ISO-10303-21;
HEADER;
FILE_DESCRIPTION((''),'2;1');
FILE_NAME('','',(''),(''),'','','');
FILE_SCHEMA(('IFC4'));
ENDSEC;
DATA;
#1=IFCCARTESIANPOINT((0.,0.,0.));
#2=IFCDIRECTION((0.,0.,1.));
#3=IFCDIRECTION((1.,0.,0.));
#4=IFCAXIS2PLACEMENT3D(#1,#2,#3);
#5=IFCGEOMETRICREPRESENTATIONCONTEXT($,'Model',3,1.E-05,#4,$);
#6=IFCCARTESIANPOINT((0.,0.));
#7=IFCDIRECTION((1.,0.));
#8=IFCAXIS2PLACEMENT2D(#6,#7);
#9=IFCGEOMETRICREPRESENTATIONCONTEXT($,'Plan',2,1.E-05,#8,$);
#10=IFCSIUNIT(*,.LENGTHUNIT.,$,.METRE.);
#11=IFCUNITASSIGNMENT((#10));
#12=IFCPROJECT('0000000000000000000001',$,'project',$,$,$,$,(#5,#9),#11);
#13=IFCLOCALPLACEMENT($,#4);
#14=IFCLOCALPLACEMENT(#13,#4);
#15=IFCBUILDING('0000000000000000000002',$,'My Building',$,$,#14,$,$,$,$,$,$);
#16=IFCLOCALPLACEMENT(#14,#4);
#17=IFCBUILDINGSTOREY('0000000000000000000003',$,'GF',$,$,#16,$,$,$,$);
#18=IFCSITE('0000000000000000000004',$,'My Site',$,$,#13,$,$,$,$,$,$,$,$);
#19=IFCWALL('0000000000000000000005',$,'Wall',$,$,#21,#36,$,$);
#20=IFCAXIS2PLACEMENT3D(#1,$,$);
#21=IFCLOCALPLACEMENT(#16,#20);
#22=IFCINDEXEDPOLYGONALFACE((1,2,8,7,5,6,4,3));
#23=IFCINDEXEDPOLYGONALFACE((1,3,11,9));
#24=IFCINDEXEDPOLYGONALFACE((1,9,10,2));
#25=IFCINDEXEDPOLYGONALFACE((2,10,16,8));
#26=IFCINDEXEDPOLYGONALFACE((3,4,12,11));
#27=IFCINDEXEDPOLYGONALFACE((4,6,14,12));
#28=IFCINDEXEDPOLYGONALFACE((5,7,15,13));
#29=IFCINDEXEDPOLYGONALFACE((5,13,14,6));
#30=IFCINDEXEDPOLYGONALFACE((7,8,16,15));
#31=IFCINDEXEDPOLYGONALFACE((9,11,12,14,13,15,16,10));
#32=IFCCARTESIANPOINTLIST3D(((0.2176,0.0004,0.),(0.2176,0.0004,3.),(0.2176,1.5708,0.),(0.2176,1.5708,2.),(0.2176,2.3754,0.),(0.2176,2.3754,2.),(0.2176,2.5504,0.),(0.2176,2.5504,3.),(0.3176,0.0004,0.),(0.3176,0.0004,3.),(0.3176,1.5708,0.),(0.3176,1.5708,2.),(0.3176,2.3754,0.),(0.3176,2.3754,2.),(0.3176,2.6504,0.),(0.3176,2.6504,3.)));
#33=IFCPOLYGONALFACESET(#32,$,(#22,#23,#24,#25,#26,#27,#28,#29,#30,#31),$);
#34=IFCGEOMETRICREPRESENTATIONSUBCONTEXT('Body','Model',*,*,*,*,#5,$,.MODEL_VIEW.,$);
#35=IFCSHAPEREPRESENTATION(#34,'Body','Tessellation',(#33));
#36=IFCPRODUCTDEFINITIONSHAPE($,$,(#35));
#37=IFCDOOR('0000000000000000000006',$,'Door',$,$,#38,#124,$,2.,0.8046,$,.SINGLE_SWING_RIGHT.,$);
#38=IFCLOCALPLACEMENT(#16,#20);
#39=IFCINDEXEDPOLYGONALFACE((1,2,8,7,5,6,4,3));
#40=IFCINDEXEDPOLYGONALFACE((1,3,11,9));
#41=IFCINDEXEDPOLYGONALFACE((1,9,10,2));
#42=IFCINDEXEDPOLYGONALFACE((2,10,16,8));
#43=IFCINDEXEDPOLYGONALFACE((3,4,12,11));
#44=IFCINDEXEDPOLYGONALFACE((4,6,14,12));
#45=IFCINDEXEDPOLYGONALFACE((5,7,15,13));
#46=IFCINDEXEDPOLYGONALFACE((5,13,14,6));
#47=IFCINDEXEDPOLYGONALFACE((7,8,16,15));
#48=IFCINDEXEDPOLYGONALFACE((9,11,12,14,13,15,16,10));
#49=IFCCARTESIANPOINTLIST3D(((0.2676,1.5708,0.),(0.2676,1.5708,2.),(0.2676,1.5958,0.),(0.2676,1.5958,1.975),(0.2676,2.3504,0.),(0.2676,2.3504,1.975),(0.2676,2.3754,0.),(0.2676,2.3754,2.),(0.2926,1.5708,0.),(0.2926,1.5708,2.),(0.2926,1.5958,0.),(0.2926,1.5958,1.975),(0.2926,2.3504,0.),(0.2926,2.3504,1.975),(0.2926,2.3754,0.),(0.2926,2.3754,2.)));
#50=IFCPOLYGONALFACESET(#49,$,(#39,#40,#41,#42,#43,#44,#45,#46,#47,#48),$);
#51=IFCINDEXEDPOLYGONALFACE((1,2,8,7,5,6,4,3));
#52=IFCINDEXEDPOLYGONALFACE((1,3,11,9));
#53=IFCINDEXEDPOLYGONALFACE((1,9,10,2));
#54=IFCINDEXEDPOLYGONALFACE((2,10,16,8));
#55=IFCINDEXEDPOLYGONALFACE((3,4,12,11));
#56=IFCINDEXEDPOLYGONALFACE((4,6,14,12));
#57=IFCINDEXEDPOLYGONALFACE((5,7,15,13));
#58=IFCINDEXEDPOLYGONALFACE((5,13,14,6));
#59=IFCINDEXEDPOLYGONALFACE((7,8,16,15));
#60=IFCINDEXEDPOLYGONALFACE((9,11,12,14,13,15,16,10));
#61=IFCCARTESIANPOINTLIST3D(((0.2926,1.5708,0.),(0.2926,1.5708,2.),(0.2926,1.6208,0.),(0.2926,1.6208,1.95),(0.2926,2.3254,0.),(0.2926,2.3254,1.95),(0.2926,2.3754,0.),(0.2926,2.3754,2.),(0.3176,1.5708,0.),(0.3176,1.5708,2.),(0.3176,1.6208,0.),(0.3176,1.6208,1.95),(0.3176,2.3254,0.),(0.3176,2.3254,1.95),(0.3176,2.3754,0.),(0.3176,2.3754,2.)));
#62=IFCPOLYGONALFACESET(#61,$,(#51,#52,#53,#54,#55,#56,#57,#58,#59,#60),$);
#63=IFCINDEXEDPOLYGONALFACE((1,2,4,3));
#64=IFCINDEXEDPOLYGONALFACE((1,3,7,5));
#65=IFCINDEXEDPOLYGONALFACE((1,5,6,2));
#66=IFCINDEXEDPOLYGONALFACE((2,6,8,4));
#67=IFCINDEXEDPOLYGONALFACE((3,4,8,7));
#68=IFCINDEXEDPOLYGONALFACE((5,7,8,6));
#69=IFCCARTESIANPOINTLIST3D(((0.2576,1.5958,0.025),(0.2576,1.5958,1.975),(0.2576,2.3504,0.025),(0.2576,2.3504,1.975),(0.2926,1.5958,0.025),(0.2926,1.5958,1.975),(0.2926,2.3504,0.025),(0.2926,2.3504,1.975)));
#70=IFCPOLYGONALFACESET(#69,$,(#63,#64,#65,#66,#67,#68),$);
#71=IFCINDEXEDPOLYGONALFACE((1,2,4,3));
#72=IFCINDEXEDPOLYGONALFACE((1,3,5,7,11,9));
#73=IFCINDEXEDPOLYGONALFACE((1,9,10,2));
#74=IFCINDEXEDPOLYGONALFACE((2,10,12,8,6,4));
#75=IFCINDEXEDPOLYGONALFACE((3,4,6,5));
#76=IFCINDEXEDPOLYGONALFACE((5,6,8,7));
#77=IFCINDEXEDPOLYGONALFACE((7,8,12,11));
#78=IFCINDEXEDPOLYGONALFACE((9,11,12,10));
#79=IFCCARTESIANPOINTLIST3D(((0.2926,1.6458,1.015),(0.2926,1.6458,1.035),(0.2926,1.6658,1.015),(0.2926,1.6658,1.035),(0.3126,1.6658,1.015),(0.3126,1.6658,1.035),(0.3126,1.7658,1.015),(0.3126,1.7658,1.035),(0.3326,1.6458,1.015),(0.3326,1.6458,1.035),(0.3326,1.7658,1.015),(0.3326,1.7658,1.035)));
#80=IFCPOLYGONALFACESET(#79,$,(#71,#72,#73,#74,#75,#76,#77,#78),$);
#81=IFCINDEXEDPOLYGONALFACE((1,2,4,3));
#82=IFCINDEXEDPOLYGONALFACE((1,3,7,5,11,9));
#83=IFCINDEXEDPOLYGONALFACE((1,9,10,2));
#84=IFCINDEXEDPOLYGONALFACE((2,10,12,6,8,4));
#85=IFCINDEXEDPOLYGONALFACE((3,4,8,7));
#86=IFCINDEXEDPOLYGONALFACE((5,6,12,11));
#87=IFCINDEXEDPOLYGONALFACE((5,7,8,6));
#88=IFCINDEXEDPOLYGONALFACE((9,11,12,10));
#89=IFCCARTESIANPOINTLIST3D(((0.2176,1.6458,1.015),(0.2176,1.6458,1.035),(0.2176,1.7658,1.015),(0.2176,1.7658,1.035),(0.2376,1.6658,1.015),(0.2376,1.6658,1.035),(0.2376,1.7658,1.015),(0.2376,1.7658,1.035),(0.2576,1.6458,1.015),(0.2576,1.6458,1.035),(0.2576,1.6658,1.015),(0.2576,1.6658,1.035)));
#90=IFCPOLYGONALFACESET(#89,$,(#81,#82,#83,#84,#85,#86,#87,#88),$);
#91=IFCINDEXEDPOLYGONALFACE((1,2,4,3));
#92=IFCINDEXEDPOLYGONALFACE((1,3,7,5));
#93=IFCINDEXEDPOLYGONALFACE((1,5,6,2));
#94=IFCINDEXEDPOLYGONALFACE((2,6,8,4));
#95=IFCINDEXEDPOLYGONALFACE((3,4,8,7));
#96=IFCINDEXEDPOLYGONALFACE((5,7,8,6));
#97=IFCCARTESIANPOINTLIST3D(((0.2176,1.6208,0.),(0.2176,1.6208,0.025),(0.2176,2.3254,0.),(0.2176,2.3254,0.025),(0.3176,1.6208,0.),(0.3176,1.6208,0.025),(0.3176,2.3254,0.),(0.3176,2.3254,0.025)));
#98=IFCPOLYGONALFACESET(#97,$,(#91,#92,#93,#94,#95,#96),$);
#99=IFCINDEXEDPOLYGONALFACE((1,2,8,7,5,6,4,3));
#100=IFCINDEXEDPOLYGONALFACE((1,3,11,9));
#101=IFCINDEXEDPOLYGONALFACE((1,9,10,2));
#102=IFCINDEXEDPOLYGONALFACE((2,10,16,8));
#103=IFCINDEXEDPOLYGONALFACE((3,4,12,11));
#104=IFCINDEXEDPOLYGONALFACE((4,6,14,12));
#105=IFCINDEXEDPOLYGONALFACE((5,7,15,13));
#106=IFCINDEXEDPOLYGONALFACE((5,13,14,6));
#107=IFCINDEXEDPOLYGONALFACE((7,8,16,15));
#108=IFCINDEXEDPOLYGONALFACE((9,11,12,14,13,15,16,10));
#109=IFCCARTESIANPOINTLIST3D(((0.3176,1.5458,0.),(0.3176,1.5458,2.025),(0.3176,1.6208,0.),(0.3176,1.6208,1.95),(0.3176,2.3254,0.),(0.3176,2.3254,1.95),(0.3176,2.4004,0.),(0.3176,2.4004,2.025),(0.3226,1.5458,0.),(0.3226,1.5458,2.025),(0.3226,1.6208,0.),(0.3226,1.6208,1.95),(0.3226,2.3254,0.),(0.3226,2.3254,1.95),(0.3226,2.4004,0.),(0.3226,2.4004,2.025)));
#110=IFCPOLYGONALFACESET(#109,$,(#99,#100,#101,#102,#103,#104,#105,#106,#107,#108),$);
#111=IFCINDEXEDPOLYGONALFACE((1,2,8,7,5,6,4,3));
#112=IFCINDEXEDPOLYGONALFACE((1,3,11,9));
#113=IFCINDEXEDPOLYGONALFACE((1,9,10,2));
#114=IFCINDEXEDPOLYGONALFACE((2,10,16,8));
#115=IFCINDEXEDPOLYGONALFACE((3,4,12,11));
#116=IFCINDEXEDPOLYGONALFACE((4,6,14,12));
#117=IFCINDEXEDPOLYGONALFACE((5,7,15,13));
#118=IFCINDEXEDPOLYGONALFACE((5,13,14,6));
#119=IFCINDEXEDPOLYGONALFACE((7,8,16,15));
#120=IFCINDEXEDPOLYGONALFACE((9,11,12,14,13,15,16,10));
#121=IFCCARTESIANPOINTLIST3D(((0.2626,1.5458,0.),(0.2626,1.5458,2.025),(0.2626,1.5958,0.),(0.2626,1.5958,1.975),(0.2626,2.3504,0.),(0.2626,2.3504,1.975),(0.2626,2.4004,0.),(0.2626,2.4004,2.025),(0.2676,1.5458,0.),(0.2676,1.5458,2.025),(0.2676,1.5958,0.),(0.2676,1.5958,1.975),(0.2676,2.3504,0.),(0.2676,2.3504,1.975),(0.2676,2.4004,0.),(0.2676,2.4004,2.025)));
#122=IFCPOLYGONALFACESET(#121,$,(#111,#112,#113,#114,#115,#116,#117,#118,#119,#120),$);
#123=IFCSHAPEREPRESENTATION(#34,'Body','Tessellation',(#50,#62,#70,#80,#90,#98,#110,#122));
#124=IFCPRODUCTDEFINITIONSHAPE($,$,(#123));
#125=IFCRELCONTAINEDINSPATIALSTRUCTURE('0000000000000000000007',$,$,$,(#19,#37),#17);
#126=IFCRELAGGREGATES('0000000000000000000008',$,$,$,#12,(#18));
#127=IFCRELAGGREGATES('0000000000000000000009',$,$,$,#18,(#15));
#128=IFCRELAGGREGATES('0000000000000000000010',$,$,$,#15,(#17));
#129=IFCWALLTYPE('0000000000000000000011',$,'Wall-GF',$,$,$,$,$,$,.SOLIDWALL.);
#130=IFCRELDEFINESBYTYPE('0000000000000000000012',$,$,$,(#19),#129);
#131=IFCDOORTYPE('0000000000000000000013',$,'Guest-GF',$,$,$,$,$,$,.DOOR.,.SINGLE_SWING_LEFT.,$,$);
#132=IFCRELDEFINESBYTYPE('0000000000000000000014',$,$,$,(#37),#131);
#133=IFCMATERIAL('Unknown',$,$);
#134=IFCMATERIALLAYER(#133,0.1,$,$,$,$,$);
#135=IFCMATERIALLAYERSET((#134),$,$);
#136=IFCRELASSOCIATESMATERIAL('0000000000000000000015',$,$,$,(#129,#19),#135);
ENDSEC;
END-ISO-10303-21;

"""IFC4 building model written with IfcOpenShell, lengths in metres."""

from ifc_helpers import new_model, entity, si_unit, frame, origin_with_axes, origin_2d_with_axis, place, context, subcontext, project, spatial, line, indexed_curve, outline, extrude, shape, source, transform, mapped, material, layer, layer_set, layer_usage, type_object, type_shapes, element, fill, save


model = new_model("IFC4")

# Units and contexts
model_context = context("Model", 3, precision=1e-05, world=origin_with_axes())
plan_context = context("Plan", 2, precision=1e-05, world=origin_2d_with_axis())
body_context_1 = subcontext(model_context, "Body", "Model", "MODEL_VIEW")
body_context_2 = subcontext(plan_context, "Body", "Plan", "PLAN_VIEW")
ifc_project = project(units=[si_unit("LENGTHUNIT", "METRE")], contexts=[model_context, plan_context])

# Site, building, storey
site_placement = place(None, origin_with_axes())
site = spatial("IfcSite", under=ifc_project, at=site_placement, Name="My Site")
building_placement = place(site_placement, origin_with_axes())
building = spatial("IfcBuilding", under=site, at=building_placement, Name="My Building")
storey_placement = place(building_placement, origin_with_axes())
storey = spatial("IfcBuildingStorey", under=building, at=storey_placement, Name="GF")

# Shared definitions
ifc_material = material(Name="Unknown")

# Shared definitions
ifc_layer_1 = layer(ifc_material, 0.1)
ifc_layer_set_1 = layer_set([ifc_layer_1])
wall_type = type_object("IfcWallType", Name="Wall-GF", PredefinedType="SOLIDWALL", material=ifc_layer_set_1)

# Wall, opening, door
ifc_layer_usage_1 = layer_usage(ifc_layer_set_1, "AXIS2", "POSITIVE", 0.0)
wall_1_placement = place(storey_placement, frame((0.3176, 0.0004, 0.0), z_axis=(0.0, 0.0, 1.0), x_axis=(0.0, 1.0, 0.0)))
wall_1 = element("IfcWall", 1, at=wall_1_placement, inside=storey, type_object=wall_type, material=ifc_layer_usage_1, Name="Wall", context=body_context_1, shape_type="SweptSolid", body=[
    extrude(outline(indexed_curve([(0.0, 0.0), (0.0, 0.1), (2.55, 0.1), (2.65, 0.0)], segments=[line(1, 2, 3, 4, 1)])), origin_with_axes(), (0.0, 0.0, 1.0), 3.0),
])
shared_shape_1 = source(origin_with_axes(), body_context_1, "Body", "SweptSolid", [
    extrude(outline(indexed_curve([(0.0, 0.0), (0.8046, 0.0), (0.8046, 2.0), (0.0, 2.0)], segments=[line(1, 2, 3, 4, 1)])), frame((0.0, -0.6, 0.0), z_axis=(0.0, -1.0, 0.0), x_axis=(1.0, 0.0, 0.0)), (0.0, 0.0, -1.0), 1.2),
])
opening_1_placement = place(wall_1_placement, frame((1.5705, 0.0, 0.0), z_axis=(0.0, 0.0, 1.0), x_axis=(1.0, 0.0, 0.0)))
opening_1 = element("IfcOpeningElement", 2, at=opening_1_placement, cuts=wall_1, PredefinedType="OPENING", context=body_context_1, shape_type="MappedRepresentation", body=[
    mapped(shared_shape_1, transform((0.0, 0.0, 0.0), x_axis=(1.0, 0.0, 0.0), y_axis=(0.0, 1.0, 0.0), z_axis=(0.0, 0.0, 1.0), scale=1.0)),
])
door_type_1 = type_object("IfcDoorType", Name="Guest-GF", OperationType="SINGLE_SWING_LEFT", PredefinedType="DOOR")
shared_shape_2 = source(origin_with_axes(), body_context_1, "Body", "SweptSolid", [
    extrude(outline(indexed_curve([(0.0, 0.0), (0.0, 2.0), (0.8046, 2.0), (0.8046, 0.0), (0.7796, 0.0), (0.7796, 1.975), (0.025, 1.975), (0.025, 0.0)], segments=[line(1, 2, 3, 4, 5, 6, 7, 8, 1)])), frame((0.0, 0.025, 0.0), z_axis=(0.0, -1.0, 0.0), x_axis=(1.0, 0.0, 0.0)), (0.0, 0.0, -1.0), 0.025),
    extrude(outline(indexed_curve([(0.0, 0.0), (0.0, 2.0), (0.8046, 2.0), (0.8046, 0.0), (0.7546, 0.0), (0.7546, 1.95), (0.05, 1.95), (0.05, 0.0)], segments=[line(1, 2, 3, 4, 5, 6, 7, 8, 1)])), frame((0.0, 0.0, 0.0), z_axis=(0.0, -1.0, 0.0), x_axis=(1.0, 0.0, 0.0)), (0.0, 0.0, -1.0), 0.025),
    extrude(outline(indexed_curve([(0.0, 0.0), (0.7546, 0.0), (0.7546, 0.035), (0.0, 0.035)], segments=[line(1, 2, 3, 4, 1)])), frame((0.025, 0.025, 0.025), z_axis=(0.0, 0.0, 1.0), x_axis=(1.0, 0.0, 0.0)), (0.0, 0.0, 1.0), 1.95),
    extrude(outline(indexed_curve([(0.0, 0.0), (0.0, -0.04), (0.12, -0.04), (0.12, -0.02), (0.02, -0.02), (0.02, 0.0)], segments=[line(1, 2, 3, 4, 5, 6, 1)])), frame((0.075, 0.025, 1.015), z_axis=(0.0, 0.0, 1.0), x_axis=(1.0, 0.0, 0.0)), (0.0, 0.0, 1.0), 0.02),
    extrude(outline(indexed_curve([(0.0, 0.0), (0.0, 0.04), (0.12, 0.04), (0.12, 0.02), (0.02, 0.02), (0.02, 0.0)], segments=[line(1, 2, 3, 4, 5, 6, 1)])), frame((0.075, 0.06, 1.015), z_axis=(0.0, 0.0, 1.0), x_axis=(1.0, 0.0, 0.0)), (0.0, 0.0, 1.0), 0.02),
    extrude(outline(indexed_curve([(0.0, 0.0), (0.7046, 0.0), (0.7046, 0.1), (0.0, 0.1)], segments=[line(1, 2, 3, 4, 1)])), frame((0.05, 0.0, 0.0), z_axis=(0.0, 0.0, 1.0), x_axis=(1.0, 0.0, 0.0)), (0.0, 0.0, 1.0), 0.025),
    extrude(outline(indexed_curve([(0.0, 0.0), (0.0, 2.025), (0.8546, 2.025), (0.8546, 0.0), (0.7796, 0.0), (0.7796, 1.95), (0.075, 1.95), (0.075, 0.0)], segments=[line(1, 2, 3, 4, 5, 6, 7, 8, 1)])), frame((-0.025, -0.005, 0.0), z_axis=(0.0, -1.0, 0.0), x_axis=(1.0, 0.0, 0.0)), (0.0, 0.0, -1.0), 0.005),
    extrude(outline(indexed_curve([(0.0, 0.0), (0.0, 2.025), (0.8546, 2.025), (0.8546, 0.0), (0.8046, 0.0), (0.8046, 1.975), (0.05, 1.975), (0.05, 0.0)], segments=[line(1, 2, 3, 4, 5, 6, 7, 8, 1)])), frame((-0.025, 0.05, 0.0), z_axis=(0.0, -1.0, 0.0), x_axis=(1.0, 0.0, 0.0)), (0.0, 0.0, -1.0), 0.005),
])
shared_shape_3 = source(origin_with_axes(), body_context_2, "Body", "Curve2D", [
    entity("IfcIndexedPolyCurve", entity("IfcCartesianPointList2D", [[0.0, 0.0], [0.0, 0.05], [0.025, 0.05], [0.025, 0.025], [0.05, 0.025], [0.05, 0.0]]), [entity("IfcLineIndex", [1, 2, 3, 4, 5, 6, 1])]),
    entity("IfcIndexedPolyCurve", entity("IfcCartesianPointList2D", [[0.8046, 0.0], [0.8046, 0.05], [0.7796, 0.05], [0.7796, 0.025], [0.7546, 0.025], [0.7546, 0.0]]), [entity("IfcLineIndex", [1, 2, 3, 4, 5, 6, 1])]),
    entity("IfcTrimmedCurve", entity("IfcEllipse", entity("IfcAxis2Placement2D", entity("IfcCartesianPoint", [0.7446, 0.05]), entity("IfcDirection", [1.0, 0.0])), 0.7196, 0.7546), [entity("IfcCartesianPoint", [0.7446, 0.8046])], [entity("IfcCartesianPoint", [0.025, 0.05])], True, "CARTESIAN"),
    entity("IfcIndexedPolyCurve", entity("IfcCartesianPointList2D", [[0.7796, 0.05], [0.7446, 0.05], [0.7446, 0.8046], [0.7796, 0.8046]]), [entity("IfcLineIndex", [1, 2, 3, 4, 1])]),
])
type_shapes(door_type_1, [shared_shape_2, shared_shape_3])
door_1_placement = place(opening_1_placement, frame((0.0, 0.0, 0.0), z_axis=(0.0, 0.0, 1.0), x_axis=(1.0, 0.0, 0.0)))
door_1 = element("IfcDoor", 3, at=door_1_placement, inside=storey, type_object=door_type_1, Name="Door", OperationType="SINGLE_SWING_RIGHT", OverallHeight=2.0, OverallWidth=0.8046, shapes=[
    shape(body_context_1, "Body", "MappedRepresentation", [mapped(shared_shape_2, transform((0.0, 0.0, 0.0), x_axis=(1.0, 0.0, 0.0), y_axis=(0.0, 1.0, 0.0), z_axis=(0.0, 0.0, 1.0), scale=1.0))]),
    shape(body_context_2, "Body", "MappedRepresentation", [mapped(shared_shape_3, transform((0.0, 0.0, 0.0), x_axis=(1.0, 0.0, 0.0), y_axis=(0.0, 1.0, 0.0), z_axis=(0.0, 0.0, 1.0), scale=1.0))]),
])
fill(opening_1, door_1)

save(model, "model.ifc")
